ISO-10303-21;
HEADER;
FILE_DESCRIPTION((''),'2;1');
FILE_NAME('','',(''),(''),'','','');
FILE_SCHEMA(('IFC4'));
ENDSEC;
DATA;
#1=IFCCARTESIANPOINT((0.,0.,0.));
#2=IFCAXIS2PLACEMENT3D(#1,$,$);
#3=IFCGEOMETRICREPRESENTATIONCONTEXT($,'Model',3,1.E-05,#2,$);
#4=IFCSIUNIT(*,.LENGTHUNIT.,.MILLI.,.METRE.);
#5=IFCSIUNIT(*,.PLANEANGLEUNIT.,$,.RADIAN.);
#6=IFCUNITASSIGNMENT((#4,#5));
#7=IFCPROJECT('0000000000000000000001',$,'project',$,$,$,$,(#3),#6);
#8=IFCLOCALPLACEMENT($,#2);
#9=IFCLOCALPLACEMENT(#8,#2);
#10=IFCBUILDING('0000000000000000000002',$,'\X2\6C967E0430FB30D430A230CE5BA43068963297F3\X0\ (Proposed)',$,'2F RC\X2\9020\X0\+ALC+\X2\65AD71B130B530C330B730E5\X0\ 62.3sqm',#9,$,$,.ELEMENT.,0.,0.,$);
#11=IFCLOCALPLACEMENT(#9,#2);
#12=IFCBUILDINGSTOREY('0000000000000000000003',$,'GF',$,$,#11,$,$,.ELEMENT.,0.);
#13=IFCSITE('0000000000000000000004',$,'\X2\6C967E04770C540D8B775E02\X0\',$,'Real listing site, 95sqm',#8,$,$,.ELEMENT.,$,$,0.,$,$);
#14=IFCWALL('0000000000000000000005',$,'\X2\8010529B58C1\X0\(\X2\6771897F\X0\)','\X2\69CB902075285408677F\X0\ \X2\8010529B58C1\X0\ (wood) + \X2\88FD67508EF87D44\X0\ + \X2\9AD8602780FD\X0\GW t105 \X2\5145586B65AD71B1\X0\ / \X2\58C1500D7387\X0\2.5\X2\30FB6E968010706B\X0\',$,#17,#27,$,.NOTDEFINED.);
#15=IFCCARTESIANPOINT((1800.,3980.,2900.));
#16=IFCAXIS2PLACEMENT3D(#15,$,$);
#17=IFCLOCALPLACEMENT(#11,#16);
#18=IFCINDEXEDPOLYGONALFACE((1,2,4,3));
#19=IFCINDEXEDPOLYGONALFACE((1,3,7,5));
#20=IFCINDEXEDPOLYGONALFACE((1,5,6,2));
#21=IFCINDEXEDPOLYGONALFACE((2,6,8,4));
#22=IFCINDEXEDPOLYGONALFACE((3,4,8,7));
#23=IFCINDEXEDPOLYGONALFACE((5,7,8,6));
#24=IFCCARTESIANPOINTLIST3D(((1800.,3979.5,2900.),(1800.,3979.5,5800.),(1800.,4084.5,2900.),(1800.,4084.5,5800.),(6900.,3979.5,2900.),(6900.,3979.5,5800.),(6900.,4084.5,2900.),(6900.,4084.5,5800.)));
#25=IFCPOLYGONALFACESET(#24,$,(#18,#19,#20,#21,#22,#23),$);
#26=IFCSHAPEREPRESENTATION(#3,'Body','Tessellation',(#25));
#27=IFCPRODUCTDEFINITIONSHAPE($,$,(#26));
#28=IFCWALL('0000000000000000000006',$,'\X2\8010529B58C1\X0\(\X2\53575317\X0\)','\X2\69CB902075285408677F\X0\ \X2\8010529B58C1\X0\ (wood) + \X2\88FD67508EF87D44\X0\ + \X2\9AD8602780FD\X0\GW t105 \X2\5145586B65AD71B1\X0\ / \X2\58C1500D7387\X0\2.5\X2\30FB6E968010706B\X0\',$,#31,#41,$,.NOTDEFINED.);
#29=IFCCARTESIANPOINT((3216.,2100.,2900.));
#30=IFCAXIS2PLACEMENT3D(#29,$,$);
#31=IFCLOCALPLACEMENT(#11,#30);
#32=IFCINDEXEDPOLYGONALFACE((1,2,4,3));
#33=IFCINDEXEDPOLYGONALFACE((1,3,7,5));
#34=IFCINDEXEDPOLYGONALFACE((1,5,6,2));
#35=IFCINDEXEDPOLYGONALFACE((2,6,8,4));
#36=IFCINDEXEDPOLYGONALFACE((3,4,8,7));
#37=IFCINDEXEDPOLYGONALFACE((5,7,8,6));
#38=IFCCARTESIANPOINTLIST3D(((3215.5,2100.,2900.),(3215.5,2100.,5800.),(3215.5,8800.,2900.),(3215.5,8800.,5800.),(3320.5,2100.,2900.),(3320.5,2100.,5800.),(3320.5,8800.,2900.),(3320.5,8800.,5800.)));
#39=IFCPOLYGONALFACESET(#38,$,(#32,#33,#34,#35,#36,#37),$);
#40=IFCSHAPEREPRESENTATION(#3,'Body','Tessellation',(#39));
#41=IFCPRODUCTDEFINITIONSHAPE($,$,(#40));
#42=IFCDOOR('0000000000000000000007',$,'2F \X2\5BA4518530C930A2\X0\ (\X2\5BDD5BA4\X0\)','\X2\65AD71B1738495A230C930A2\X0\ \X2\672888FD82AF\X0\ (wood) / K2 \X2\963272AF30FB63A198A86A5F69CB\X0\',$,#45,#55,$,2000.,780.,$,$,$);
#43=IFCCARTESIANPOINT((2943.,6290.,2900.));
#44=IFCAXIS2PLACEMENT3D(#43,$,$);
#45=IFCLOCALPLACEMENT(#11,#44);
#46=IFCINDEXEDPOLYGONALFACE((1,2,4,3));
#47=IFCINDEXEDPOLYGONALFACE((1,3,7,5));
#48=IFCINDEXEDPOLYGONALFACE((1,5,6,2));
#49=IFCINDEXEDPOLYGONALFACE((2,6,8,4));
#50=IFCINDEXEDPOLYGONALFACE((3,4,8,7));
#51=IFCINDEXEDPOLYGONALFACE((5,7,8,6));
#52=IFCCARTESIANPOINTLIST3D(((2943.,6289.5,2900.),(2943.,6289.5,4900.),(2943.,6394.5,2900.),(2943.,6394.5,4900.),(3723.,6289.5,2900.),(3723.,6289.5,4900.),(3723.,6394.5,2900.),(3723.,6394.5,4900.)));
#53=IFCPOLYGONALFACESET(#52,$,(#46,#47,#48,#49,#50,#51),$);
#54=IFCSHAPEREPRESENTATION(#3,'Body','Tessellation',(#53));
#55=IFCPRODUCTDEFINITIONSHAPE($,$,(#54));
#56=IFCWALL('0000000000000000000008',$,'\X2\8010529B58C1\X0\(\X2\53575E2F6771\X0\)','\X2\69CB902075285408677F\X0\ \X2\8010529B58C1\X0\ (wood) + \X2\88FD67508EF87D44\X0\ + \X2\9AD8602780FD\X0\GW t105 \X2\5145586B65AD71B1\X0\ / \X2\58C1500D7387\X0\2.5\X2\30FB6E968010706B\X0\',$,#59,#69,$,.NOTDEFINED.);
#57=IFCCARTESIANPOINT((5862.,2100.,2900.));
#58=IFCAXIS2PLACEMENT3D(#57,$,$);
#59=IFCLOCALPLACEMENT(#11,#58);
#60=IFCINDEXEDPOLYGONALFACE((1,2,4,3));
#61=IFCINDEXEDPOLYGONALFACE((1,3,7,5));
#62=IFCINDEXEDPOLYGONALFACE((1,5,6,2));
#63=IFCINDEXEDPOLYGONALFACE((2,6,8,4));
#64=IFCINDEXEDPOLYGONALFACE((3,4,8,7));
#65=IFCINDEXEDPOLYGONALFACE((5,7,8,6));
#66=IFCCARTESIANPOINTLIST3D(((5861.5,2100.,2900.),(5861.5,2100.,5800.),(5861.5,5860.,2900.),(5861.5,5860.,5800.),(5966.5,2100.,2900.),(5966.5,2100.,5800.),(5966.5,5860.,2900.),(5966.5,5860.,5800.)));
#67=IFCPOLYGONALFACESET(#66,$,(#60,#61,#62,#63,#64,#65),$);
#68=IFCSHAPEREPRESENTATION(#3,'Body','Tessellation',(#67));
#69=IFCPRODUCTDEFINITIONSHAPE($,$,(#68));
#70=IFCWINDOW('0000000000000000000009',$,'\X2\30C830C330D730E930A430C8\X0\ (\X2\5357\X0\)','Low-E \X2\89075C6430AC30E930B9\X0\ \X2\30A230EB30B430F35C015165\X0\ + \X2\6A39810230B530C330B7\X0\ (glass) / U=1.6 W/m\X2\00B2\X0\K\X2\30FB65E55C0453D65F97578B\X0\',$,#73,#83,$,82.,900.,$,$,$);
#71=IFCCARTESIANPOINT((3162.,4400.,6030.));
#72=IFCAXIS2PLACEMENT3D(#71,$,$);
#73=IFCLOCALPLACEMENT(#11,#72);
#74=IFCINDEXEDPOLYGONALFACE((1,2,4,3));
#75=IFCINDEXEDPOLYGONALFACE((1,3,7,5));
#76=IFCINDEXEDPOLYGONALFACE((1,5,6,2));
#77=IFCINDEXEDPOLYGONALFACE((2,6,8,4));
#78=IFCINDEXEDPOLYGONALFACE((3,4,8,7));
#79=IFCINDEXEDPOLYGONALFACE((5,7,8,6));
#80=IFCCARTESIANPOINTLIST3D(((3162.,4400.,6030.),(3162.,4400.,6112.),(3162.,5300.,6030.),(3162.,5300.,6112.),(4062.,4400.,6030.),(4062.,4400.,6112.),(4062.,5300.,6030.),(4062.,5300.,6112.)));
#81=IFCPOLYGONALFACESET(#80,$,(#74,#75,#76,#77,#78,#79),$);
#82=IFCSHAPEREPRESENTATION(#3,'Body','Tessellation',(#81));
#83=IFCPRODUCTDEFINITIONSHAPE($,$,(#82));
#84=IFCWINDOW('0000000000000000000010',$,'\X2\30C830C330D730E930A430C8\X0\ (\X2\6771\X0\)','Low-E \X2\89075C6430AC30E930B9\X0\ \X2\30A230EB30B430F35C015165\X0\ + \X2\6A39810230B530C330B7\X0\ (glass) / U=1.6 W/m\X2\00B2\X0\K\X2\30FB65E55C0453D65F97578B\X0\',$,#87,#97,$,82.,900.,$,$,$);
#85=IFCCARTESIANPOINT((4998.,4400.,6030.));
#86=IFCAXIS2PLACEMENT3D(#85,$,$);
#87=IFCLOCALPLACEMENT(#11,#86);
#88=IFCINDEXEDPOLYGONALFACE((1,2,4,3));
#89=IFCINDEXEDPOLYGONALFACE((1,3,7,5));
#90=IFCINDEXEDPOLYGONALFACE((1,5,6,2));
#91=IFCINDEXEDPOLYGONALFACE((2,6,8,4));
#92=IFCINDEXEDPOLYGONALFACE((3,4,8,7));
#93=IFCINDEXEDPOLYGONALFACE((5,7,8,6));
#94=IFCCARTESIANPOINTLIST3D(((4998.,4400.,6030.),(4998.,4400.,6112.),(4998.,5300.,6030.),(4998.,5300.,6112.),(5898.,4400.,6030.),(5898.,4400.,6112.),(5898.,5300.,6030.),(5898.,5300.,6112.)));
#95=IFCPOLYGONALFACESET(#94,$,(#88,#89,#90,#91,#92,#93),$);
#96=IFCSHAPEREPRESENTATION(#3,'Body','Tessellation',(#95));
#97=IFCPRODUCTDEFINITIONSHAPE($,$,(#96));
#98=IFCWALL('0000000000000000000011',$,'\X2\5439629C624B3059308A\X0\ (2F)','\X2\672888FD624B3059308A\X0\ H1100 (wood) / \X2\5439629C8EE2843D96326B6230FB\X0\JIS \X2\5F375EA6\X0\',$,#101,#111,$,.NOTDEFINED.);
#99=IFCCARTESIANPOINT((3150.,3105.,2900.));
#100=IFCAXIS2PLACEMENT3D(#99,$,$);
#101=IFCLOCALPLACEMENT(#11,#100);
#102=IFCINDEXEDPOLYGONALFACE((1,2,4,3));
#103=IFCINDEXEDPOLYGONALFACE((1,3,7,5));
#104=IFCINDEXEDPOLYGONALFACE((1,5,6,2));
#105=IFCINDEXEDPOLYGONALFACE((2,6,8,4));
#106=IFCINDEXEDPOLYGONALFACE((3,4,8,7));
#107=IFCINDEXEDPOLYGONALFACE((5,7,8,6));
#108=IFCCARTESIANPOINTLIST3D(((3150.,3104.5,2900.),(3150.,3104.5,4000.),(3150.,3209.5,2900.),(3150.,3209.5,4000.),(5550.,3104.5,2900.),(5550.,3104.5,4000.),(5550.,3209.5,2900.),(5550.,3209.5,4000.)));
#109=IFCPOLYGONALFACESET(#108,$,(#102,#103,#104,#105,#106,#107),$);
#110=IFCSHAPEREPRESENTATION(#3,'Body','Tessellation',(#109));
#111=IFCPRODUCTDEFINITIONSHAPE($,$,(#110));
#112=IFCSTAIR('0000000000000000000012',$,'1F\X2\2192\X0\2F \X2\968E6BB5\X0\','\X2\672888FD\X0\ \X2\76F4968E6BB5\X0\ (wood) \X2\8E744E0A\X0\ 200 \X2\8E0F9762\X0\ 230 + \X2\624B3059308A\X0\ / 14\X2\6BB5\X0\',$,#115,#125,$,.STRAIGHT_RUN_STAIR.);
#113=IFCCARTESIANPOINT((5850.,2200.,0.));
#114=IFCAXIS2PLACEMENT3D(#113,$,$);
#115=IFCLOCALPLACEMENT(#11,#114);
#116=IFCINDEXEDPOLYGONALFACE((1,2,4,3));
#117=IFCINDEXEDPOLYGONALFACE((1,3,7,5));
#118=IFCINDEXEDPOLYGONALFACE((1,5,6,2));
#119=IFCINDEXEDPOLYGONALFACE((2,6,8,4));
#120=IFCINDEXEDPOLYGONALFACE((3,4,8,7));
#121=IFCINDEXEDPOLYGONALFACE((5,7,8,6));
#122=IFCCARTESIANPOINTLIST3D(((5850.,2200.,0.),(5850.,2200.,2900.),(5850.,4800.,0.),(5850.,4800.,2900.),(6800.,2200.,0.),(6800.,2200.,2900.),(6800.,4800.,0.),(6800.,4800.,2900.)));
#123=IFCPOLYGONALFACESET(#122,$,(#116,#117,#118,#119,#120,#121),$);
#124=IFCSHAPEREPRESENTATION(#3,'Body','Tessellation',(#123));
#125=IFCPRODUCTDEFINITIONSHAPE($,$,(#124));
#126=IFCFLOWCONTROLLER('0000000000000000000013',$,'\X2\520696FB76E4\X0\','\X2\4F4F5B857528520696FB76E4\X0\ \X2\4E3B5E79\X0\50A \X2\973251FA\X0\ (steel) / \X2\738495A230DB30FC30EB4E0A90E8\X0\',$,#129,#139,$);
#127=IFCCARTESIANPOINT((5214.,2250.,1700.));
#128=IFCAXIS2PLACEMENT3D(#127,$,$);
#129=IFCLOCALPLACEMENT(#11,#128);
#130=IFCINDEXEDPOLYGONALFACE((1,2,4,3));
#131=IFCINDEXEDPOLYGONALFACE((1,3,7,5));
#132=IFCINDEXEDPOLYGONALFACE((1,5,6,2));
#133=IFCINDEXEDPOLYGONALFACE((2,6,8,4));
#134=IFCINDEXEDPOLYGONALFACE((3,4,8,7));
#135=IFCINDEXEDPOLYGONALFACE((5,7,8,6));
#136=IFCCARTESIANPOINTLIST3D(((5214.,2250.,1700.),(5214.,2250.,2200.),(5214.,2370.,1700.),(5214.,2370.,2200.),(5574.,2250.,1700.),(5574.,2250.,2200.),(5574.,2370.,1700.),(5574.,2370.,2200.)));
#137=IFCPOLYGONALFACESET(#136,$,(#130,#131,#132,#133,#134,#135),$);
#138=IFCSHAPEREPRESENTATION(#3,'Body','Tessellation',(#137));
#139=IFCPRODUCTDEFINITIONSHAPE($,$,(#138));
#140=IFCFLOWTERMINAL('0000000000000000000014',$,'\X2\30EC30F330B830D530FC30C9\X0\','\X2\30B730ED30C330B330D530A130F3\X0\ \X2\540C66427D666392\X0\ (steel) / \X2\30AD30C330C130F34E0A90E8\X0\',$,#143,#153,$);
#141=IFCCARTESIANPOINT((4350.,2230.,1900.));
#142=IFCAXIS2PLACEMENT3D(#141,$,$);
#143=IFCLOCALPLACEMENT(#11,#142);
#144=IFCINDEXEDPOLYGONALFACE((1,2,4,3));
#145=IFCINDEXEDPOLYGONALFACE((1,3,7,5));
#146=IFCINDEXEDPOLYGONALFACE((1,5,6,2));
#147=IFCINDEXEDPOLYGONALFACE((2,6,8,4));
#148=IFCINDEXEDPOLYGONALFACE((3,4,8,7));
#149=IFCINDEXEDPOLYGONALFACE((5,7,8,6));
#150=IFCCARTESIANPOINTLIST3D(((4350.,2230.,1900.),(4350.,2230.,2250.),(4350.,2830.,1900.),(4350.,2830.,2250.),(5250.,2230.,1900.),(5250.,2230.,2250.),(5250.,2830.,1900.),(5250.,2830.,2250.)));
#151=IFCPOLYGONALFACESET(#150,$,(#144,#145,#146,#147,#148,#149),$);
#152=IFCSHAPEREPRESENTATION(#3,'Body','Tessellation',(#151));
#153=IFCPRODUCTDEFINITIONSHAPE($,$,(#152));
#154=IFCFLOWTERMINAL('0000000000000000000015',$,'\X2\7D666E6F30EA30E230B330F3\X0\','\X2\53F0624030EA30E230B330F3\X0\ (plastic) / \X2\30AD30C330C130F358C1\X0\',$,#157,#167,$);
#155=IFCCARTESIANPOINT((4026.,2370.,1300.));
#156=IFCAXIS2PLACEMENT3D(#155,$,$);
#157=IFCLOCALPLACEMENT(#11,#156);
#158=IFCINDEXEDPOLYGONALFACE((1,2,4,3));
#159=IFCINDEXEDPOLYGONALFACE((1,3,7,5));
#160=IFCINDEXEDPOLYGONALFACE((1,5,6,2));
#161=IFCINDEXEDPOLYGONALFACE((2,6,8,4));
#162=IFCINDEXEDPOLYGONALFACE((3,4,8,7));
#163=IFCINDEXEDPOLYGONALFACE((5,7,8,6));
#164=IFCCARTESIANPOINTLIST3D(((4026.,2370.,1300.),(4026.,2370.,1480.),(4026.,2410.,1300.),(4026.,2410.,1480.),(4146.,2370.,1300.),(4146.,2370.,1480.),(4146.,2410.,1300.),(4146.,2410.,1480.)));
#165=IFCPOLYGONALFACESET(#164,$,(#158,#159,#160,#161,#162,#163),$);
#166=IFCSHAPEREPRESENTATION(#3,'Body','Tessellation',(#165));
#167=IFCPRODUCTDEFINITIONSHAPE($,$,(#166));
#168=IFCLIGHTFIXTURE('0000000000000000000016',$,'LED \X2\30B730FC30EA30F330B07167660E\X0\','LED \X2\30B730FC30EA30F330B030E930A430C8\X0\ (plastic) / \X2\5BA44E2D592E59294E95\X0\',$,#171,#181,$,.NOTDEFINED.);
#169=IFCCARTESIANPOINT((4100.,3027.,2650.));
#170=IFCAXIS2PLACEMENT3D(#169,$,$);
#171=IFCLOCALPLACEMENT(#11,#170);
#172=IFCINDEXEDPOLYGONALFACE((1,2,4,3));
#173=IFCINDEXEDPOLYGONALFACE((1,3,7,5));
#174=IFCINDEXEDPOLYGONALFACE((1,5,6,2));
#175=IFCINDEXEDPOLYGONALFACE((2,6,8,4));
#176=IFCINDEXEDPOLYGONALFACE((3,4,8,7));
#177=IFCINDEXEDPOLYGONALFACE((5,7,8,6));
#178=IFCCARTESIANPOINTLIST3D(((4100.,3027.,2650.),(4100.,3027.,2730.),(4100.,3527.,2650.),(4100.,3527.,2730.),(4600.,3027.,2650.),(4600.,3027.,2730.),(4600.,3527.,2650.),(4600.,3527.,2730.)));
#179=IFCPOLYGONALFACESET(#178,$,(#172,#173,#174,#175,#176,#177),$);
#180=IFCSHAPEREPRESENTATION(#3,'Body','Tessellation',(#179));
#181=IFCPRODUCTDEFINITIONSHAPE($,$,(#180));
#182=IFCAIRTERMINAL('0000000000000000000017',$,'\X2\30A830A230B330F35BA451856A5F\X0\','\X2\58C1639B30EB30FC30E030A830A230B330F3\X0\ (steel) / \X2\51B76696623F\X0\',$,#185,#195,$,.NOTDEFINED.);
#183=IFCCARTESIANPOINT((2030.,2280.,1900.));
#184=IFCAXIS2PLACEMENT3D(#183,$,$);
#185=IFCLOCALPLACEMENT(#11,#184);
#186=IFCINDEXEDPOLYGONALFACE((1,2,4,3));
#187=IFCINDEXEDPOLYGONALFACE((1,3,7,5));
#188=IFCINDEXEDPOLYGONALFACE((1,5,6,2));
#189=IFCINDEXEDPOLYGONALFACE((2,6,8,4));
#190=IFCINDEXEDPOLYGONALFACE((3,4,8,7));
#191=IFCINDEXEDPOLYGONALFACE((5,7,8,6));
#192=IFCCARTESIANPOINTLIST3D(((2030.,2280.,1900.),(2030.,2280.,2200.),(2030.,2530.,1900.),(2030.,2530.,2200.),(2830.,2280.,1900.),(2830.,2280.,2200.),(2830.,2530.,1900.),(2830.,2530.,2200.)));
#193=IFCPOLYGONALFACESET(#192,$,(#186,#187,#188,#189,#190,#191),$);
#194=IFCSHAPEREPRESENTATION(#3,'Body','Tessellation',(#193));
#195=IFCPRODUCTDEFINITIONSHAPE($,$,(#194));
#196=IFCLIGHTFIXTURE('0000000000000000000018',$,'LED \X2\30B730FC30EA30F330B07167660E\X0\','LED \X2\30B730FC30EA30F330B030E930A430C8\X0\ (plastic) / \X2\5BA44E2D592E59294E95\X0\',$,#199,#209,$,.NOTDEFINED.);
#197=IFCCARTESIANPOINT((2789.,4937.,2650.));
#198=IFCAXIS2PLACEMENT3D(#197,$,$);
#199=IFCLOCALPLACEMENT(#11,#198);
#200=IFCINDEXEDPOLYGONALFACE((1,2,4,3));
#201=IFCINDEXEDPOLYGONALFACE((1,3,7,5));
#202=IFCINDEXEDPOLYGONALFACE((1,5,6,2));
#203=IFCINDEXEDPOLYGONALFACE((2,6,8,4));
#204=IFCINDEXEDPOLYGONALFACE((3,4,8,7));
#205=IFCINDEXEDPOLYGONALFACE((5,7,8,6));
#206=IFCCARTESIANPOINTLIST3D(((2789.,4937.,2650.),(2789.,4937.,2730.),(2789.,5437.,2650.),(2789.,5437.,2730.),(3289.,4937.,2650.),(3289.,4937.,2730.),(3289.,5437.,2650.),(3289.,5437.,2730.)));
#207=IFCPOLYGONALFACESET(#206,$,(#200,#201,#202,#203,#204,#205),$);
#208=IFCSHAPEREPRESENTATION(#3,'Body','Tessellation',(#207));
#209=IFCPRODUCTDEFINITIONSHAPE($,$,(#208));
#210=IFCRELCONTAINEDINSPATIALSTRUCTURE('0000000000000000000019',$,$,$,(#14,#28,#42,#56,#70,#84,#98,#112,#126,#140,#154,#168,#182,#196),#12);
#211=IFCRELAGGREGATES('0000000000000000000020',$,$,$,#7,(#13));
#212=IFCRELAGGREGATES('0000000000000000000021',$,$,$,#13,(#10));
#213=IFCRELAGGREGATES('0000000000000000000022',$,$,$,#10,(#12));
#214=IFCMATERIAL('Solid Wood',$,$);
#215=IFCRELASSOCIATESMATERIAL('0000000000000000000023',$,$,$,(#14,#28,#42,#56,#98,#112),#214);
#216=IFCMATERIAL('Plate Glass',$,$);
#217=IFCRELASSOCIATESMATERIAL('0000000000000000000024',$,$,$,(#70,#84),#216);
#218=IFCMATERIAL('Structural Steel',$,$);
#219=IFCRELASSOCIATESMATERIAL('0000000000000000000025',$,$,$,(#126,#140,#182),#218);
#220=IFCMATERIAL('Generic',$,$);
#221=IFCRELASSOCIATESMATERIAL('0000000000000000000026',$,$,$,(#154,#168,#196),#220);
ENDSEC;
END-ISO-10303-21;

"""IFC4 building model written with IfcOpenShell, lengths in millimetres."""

from ifc_helpers import new_model, si_unit, frame, frame_2d, origin, place, context, project, spatial, rectangle, extrude, material, element, fill, save


model = new_model("IFC4")

# Units and contexts
model_context = context("Model", 3, precision=1e-05, world=origin())
ifc_project = project(units=[si_unit("LENGTHUNIT", "METRE", prefix="MILLI"), si_unit("PLANEANGLEUNIT", "RADIAN")], contexts=[model_context])

# Site, building, storey
site_placement = place(None, origin())
site = spatial("IfcSite", under=ifc_project, at=site_placement, Name="沖縄県名護市", ObjectType="Real listing site, 95sqm", CompositionType="ELEMENT", RefElevation=0.0)
building_placement = place(site_placement, origin())
building = spatial("IfcBuilding", under=site, at=building_placement, Name="沖縄・ピアノ室と防音 (Proposed)", ObjectType="2F RC造+ALC+断熱サッシュ 62.3sqm", CompositionType="ELEMENT", ElevationOfRefHeight=0.0, ElevationOfTerrain=0.0)
storey_placement = place(building_placement, origin())
storey = spatial("IfcBuildingStorey", under=building, at=storey_placement, Name="GF", CompositionType="ELEMENT", Elevation=0.0)

# Shared definitions
ifc_material_1 = material(Name="Solid Wood")

# Wall
wall_1_placement = place(storey_placement, frame((1800.0, 3980.0, 2900.0)))
element("IfcWall", 1, at=wall_1_placement, inside=storey, material=ifc_material_1, Name="耐力壁(東西)", Description="構造用合板 耐力壁 (wood) + 製材軸組 + 高性能GW t105 充填断熱 / 壁倍率2.5・準耐火", PredefinedType="NOTDEFINED", context=model_context, shape_type="SweptSolid", body=[
    extrude(rectangle(XDim=5100.0, YDim=105.0, at=frame_2d((2550.0, 52.0))), frame((1800.0, 3980.0, 2900.0)), (0.0, 0.0, 1.0), 2900.0),
])

# Wall, opening, door
wall_2_placement = place(storey_placement, frame((3216.0, 2100.0, 2900.0)))
wall_2 = element("IfcWall", 2, at=wall_2_placement, inside=storey, material=ifc_material_1, Name="耐力壁(南北)", Description="構造用合板 耐力壁 (wood) + 製材軸組 + 高性能GW t105 充填断熱 / 壁倍率2.5・準耐火", PredefinedType="NOTDEFINED", context=model_context, shape_type="SweptSolid", body=[
    extrude(rectangle(XDim=105.0, YDim=6700.0, at=frame_2d((52.0, 3350.0))), frame((3216.0, 2100.0, 2900.0)), (0.0, 0.0, 1.0), 2900.0),
])
opening_placement = place(storey_placement, frame((2943.0, 6290.0, 2900.0)))
opening = element("IfcOpeningElement", 3, at=opening_placement, cuts=wall_2, PredefinedType="NOTDEFINED", context=model_context, shape_type="SweptSolid", body=[
    extrude(rectangle(XDim=780.0, YDim=105.0, at=frame_2d((390.0, 52.0))), frame((2943.0, 6290.0, 2900.0)), (0.0, 0.0, 1.0), 2000.0),
])
door_placement = place(storey_placement, frame((2943.0, 6290.0, 2900.0)))
door = element("IfcDoor", 4, at=door_placement, inside=storey, material=ifc_material_1, Name="2F 室内ドア (寝室)", Description="断熱玄関ドア 木製芯 (wood) / K2 防犯・採風機構", OverallHeight=2000.0, OverallWidth=780.0, context=model_context, shape_type="SweptSolid", body=[
    extrude(rectangle(XDim=780.0, YDim=105.0, at=frame_2d((390.0, 52.0))), frame((2943.0, 6290.0, 2900.0)), (0.0, 0.0, 1.0), 2000.0),
])
fill(opening, door)

# Wall
wall_3_placement = place(storey_placement, frame((5862.0, 2100.0, 2900.0)))
element("IfcWall", 5, at=wall_3_placement, inside=storey, material=ifc_material_1, Name="耐力壁(南帯東)", Description="構造用合板 耐力壁 (wood) + 製材軸組 + 高性能GW t105 充填断熱 / 壁倍率2.5・準耐火", PredefinedType="NOTDEFINED", context=model_context, shape_type="SweptSolid", body=[
    extrude(rectangle(XDim=105.0, YDim=3760.0, at=frame_2d((52.0, 1880.0))), frame((5862.0, 2100.0, 2900.0)), (0.0, 0.0, 1.0), 2900.0),
])

# Windows
ifc_material_2 = material(Name="Plate Glass")
window_1_placement = place(storey_placement, frame((3162.0, 4400.0, 6030.0)))
element("IfcWindow", 6, at=window_1_placement, inside=storey, material=ifc_material_2, Name="トップライト (南)", Description="Low-E 複層ガラス アルゴン封入 + 樹脂サッシ (glass) / U=1.6 W/m²K・日射取得型", OverallHeight=82.0, OverallWidth=900.0, context=model_context, shape_type="SweptSolid", body=[
    extrude(rectangle(XDim=900.0, YDim=900.0, at=frame_2d((450.0, 450.0))), frame((3162.0, 4400.0, 6030.0)), (0.0, 0.0, 1.0), 82.0),
])
window_2_placement = place(storey_placement, frame((4998.0, 4400.0, 6030.0)))
element("IfcWindow", 7, at=window_2_placement, inside=storey, material=ifc_material_2, Name="トップライト (東)", Description="Low-E 複層ガラス アルゴン封入 + 樹脂サッシ (glass) / U=1.6 W/m²K・日射取得型", OverallHeight=82.0, OverallWidth=900.0, context=model_context, shape_type="SweptSolid", body=[
    extrude(rectangle(XDim=900.0, YDim=900.0, at=frame_2d((450.0, 450.0))), frame((4998.0, 4400.0, 6030.0)), (0.0, 0.0, 1.0), 82.0),
])

# Wall
wall_4_placement = place(storey_placement, frame((3150.0, 3105.0, 2900.0)))
element("IfcWall", 8, at=wall_4_placement, inside=storey, material=ifc_material_1, Name="吹抜手すり (2F)", Description="木製手すり H1100 (wood) / 吹抜転落防止・JIS 強度", PredefinedType="NOTDEFINED", context=model_context, shape_type="SweptSolid", body=[
    extrude(rectangle(XDim=2400.0, YDim=105.0, at=frame_2d((1200.0, 52.0))), frame((3150.0, 3105.0, 2900.0)), (0.0, 0.0, 1.0), 1100.0),
])

# Stair
stair_placement = place(storey_placement, frame((5850.0, 2200.0, 0.0)))
element("IfcStair", 9, at=stair_placement, inside=storey, material=ifc_material_1, Name="1F→2F 階段", Description="木製 直階段 (wood) 蹴上 200 踏面 230 + 手すり / 14段", PredefinedType="STRAIGHT_RUN_STAIR", context=model_context, shape_type="SweptSolid", body=[
    extrude(rectangle(XDim=950.0, YDim=2600.0, at=frame_2d((475.0, 1300.0))), frame((5850.0, 2200.0, 0.0)), (0.0, 0.0, 1.0), 2900.0),
])

# Shared definitions
ifc_material_3 = material(Name="Structural Steel")

# Flow controller
flow_controller_placement = place(storey_placement, frame((5214.0, 2250.0, 1700.0)))
element("IfcFlowController", 10, at=flow_controller_placement, inside=storey, material=ifc_material_3, Name="分電盤", Description="住宅用分電盤 主幹50A 露出 (steel) / 玄関ホール上部", context=model_context, shape_type="SweptSolid", body=[
    extrude(rectangle(XDim=360.0, YDim=120.0, at=frame_2d((180.0, 60.0))), frame((5214.0, 2250.0, 1700.0)), (0.0, 0.0, 1.0), 500.0),
])

# Flow terminals
flow_terminal_1_placement = place(storey_placement, frame((4350.0, 2230.0, 1900.0)))
element("IfcFlowTerminal", 11, at=flow_terminal_1_placement, inside=storey, material=ifc_material_3, Name="レンジフード", Description="シロッコファン 同時給排 (steel) / キッチン上部", context=model_context, shape_type="SweptSolid", body=[
    extrude(rectangle(XDim=900.0, YDim=600.0, at=frame_2d((450.0, 300.0))), frame((4350.0, 2230.0, 1900.0)), (0.0, 0.0, 1.0), 350.0),
])
ifc_material_4 = material(Name="Generic")
flow_terminal_2_placement = place(storey_placement, frame((4026.0, 2370.0, 1300.0)))
element("IfcFlowTerminal", 12, at=flow_terminal_2_placement, inside=storey, material=ifc_material_4, Name="給湯リモコン", Description="台所リモコン (plastic) / キッチン壁", context=model_context, shape_type="SweptSolid", body=[
    extrude(rectangle(XDim=120.0, YDim=40.0, at=frame_2d((60.0, 20.0))), frame((4026.0, 2370.0, 1300.0)), (0.0, 0.0, 1.0), 180.0),
])

# Light fixture
light_fixture_1_placement = place(storey_placement, frame((4100.0, 3027.0, 2650.0)))
element("IfcLightFixture", 13, at=light_fixture_1_placement, inside=storey, material=ifc_material_4, Name="LED シーリング照明", Description="LED シーリングライト (plastic) / 室中央天井", PredefinedType="NOTDEFINED", context=model_context, shape_type="SweptSolid", body=[
    extrude(rectangle(XDim=500.0, YDim=500.0, at=frame_2d((250.0, 250.0))), frame((4100.0, 3027.0, 2650.0)), (0.0, 0.0, 1.0), 80.0),
])

# Air terminal
air_terminal_1_placement = place(storey_placement, frame((2030.0, 2280.0, 1900.0)))
element("IfcAirTerminal", 14, at=air_terminal_1_placement, inside=storey, material=ifc_material_3, Name="エアコン室内機", Description="壁掛ルームエアコン (steel) / 冷暖房", PredefinedType="NOTDEFINED", context=model_context, shape_type="SweptSolid", body=[
    extrude(rectangle(XDim=800.0, YDim=250.0, at=frame_2d((400.0, 125.0))), frame((2030.0, 2280.0, 1900.0)), (0.0, 0.0, 1.0), 300.0),
])

# Light fixture
light_fixture_2_placement = place(storey_placement, frame((2789.0, 4937.0, 2650.0)))
element("IfcLightFixture", 15, at=light_fixture_2_placement, inside=storey, material=ifc_material_4, Name="LED シーリング照明", Description="LED シーリングライト (plastic) / 室中央天井", PredefinedType="NOTDEFINED", context=model_context, shape_type="SweptSolid", body=[
    extrude(rectangle(XDim=500.0, YDim=500.0, at=frame_2d((250.0, 250.0))), frame((2789.0, 4937.0, 2650.0)), (0.0, 0.0, 1.0), 80.0),
])

save(model, "model.ifc")
